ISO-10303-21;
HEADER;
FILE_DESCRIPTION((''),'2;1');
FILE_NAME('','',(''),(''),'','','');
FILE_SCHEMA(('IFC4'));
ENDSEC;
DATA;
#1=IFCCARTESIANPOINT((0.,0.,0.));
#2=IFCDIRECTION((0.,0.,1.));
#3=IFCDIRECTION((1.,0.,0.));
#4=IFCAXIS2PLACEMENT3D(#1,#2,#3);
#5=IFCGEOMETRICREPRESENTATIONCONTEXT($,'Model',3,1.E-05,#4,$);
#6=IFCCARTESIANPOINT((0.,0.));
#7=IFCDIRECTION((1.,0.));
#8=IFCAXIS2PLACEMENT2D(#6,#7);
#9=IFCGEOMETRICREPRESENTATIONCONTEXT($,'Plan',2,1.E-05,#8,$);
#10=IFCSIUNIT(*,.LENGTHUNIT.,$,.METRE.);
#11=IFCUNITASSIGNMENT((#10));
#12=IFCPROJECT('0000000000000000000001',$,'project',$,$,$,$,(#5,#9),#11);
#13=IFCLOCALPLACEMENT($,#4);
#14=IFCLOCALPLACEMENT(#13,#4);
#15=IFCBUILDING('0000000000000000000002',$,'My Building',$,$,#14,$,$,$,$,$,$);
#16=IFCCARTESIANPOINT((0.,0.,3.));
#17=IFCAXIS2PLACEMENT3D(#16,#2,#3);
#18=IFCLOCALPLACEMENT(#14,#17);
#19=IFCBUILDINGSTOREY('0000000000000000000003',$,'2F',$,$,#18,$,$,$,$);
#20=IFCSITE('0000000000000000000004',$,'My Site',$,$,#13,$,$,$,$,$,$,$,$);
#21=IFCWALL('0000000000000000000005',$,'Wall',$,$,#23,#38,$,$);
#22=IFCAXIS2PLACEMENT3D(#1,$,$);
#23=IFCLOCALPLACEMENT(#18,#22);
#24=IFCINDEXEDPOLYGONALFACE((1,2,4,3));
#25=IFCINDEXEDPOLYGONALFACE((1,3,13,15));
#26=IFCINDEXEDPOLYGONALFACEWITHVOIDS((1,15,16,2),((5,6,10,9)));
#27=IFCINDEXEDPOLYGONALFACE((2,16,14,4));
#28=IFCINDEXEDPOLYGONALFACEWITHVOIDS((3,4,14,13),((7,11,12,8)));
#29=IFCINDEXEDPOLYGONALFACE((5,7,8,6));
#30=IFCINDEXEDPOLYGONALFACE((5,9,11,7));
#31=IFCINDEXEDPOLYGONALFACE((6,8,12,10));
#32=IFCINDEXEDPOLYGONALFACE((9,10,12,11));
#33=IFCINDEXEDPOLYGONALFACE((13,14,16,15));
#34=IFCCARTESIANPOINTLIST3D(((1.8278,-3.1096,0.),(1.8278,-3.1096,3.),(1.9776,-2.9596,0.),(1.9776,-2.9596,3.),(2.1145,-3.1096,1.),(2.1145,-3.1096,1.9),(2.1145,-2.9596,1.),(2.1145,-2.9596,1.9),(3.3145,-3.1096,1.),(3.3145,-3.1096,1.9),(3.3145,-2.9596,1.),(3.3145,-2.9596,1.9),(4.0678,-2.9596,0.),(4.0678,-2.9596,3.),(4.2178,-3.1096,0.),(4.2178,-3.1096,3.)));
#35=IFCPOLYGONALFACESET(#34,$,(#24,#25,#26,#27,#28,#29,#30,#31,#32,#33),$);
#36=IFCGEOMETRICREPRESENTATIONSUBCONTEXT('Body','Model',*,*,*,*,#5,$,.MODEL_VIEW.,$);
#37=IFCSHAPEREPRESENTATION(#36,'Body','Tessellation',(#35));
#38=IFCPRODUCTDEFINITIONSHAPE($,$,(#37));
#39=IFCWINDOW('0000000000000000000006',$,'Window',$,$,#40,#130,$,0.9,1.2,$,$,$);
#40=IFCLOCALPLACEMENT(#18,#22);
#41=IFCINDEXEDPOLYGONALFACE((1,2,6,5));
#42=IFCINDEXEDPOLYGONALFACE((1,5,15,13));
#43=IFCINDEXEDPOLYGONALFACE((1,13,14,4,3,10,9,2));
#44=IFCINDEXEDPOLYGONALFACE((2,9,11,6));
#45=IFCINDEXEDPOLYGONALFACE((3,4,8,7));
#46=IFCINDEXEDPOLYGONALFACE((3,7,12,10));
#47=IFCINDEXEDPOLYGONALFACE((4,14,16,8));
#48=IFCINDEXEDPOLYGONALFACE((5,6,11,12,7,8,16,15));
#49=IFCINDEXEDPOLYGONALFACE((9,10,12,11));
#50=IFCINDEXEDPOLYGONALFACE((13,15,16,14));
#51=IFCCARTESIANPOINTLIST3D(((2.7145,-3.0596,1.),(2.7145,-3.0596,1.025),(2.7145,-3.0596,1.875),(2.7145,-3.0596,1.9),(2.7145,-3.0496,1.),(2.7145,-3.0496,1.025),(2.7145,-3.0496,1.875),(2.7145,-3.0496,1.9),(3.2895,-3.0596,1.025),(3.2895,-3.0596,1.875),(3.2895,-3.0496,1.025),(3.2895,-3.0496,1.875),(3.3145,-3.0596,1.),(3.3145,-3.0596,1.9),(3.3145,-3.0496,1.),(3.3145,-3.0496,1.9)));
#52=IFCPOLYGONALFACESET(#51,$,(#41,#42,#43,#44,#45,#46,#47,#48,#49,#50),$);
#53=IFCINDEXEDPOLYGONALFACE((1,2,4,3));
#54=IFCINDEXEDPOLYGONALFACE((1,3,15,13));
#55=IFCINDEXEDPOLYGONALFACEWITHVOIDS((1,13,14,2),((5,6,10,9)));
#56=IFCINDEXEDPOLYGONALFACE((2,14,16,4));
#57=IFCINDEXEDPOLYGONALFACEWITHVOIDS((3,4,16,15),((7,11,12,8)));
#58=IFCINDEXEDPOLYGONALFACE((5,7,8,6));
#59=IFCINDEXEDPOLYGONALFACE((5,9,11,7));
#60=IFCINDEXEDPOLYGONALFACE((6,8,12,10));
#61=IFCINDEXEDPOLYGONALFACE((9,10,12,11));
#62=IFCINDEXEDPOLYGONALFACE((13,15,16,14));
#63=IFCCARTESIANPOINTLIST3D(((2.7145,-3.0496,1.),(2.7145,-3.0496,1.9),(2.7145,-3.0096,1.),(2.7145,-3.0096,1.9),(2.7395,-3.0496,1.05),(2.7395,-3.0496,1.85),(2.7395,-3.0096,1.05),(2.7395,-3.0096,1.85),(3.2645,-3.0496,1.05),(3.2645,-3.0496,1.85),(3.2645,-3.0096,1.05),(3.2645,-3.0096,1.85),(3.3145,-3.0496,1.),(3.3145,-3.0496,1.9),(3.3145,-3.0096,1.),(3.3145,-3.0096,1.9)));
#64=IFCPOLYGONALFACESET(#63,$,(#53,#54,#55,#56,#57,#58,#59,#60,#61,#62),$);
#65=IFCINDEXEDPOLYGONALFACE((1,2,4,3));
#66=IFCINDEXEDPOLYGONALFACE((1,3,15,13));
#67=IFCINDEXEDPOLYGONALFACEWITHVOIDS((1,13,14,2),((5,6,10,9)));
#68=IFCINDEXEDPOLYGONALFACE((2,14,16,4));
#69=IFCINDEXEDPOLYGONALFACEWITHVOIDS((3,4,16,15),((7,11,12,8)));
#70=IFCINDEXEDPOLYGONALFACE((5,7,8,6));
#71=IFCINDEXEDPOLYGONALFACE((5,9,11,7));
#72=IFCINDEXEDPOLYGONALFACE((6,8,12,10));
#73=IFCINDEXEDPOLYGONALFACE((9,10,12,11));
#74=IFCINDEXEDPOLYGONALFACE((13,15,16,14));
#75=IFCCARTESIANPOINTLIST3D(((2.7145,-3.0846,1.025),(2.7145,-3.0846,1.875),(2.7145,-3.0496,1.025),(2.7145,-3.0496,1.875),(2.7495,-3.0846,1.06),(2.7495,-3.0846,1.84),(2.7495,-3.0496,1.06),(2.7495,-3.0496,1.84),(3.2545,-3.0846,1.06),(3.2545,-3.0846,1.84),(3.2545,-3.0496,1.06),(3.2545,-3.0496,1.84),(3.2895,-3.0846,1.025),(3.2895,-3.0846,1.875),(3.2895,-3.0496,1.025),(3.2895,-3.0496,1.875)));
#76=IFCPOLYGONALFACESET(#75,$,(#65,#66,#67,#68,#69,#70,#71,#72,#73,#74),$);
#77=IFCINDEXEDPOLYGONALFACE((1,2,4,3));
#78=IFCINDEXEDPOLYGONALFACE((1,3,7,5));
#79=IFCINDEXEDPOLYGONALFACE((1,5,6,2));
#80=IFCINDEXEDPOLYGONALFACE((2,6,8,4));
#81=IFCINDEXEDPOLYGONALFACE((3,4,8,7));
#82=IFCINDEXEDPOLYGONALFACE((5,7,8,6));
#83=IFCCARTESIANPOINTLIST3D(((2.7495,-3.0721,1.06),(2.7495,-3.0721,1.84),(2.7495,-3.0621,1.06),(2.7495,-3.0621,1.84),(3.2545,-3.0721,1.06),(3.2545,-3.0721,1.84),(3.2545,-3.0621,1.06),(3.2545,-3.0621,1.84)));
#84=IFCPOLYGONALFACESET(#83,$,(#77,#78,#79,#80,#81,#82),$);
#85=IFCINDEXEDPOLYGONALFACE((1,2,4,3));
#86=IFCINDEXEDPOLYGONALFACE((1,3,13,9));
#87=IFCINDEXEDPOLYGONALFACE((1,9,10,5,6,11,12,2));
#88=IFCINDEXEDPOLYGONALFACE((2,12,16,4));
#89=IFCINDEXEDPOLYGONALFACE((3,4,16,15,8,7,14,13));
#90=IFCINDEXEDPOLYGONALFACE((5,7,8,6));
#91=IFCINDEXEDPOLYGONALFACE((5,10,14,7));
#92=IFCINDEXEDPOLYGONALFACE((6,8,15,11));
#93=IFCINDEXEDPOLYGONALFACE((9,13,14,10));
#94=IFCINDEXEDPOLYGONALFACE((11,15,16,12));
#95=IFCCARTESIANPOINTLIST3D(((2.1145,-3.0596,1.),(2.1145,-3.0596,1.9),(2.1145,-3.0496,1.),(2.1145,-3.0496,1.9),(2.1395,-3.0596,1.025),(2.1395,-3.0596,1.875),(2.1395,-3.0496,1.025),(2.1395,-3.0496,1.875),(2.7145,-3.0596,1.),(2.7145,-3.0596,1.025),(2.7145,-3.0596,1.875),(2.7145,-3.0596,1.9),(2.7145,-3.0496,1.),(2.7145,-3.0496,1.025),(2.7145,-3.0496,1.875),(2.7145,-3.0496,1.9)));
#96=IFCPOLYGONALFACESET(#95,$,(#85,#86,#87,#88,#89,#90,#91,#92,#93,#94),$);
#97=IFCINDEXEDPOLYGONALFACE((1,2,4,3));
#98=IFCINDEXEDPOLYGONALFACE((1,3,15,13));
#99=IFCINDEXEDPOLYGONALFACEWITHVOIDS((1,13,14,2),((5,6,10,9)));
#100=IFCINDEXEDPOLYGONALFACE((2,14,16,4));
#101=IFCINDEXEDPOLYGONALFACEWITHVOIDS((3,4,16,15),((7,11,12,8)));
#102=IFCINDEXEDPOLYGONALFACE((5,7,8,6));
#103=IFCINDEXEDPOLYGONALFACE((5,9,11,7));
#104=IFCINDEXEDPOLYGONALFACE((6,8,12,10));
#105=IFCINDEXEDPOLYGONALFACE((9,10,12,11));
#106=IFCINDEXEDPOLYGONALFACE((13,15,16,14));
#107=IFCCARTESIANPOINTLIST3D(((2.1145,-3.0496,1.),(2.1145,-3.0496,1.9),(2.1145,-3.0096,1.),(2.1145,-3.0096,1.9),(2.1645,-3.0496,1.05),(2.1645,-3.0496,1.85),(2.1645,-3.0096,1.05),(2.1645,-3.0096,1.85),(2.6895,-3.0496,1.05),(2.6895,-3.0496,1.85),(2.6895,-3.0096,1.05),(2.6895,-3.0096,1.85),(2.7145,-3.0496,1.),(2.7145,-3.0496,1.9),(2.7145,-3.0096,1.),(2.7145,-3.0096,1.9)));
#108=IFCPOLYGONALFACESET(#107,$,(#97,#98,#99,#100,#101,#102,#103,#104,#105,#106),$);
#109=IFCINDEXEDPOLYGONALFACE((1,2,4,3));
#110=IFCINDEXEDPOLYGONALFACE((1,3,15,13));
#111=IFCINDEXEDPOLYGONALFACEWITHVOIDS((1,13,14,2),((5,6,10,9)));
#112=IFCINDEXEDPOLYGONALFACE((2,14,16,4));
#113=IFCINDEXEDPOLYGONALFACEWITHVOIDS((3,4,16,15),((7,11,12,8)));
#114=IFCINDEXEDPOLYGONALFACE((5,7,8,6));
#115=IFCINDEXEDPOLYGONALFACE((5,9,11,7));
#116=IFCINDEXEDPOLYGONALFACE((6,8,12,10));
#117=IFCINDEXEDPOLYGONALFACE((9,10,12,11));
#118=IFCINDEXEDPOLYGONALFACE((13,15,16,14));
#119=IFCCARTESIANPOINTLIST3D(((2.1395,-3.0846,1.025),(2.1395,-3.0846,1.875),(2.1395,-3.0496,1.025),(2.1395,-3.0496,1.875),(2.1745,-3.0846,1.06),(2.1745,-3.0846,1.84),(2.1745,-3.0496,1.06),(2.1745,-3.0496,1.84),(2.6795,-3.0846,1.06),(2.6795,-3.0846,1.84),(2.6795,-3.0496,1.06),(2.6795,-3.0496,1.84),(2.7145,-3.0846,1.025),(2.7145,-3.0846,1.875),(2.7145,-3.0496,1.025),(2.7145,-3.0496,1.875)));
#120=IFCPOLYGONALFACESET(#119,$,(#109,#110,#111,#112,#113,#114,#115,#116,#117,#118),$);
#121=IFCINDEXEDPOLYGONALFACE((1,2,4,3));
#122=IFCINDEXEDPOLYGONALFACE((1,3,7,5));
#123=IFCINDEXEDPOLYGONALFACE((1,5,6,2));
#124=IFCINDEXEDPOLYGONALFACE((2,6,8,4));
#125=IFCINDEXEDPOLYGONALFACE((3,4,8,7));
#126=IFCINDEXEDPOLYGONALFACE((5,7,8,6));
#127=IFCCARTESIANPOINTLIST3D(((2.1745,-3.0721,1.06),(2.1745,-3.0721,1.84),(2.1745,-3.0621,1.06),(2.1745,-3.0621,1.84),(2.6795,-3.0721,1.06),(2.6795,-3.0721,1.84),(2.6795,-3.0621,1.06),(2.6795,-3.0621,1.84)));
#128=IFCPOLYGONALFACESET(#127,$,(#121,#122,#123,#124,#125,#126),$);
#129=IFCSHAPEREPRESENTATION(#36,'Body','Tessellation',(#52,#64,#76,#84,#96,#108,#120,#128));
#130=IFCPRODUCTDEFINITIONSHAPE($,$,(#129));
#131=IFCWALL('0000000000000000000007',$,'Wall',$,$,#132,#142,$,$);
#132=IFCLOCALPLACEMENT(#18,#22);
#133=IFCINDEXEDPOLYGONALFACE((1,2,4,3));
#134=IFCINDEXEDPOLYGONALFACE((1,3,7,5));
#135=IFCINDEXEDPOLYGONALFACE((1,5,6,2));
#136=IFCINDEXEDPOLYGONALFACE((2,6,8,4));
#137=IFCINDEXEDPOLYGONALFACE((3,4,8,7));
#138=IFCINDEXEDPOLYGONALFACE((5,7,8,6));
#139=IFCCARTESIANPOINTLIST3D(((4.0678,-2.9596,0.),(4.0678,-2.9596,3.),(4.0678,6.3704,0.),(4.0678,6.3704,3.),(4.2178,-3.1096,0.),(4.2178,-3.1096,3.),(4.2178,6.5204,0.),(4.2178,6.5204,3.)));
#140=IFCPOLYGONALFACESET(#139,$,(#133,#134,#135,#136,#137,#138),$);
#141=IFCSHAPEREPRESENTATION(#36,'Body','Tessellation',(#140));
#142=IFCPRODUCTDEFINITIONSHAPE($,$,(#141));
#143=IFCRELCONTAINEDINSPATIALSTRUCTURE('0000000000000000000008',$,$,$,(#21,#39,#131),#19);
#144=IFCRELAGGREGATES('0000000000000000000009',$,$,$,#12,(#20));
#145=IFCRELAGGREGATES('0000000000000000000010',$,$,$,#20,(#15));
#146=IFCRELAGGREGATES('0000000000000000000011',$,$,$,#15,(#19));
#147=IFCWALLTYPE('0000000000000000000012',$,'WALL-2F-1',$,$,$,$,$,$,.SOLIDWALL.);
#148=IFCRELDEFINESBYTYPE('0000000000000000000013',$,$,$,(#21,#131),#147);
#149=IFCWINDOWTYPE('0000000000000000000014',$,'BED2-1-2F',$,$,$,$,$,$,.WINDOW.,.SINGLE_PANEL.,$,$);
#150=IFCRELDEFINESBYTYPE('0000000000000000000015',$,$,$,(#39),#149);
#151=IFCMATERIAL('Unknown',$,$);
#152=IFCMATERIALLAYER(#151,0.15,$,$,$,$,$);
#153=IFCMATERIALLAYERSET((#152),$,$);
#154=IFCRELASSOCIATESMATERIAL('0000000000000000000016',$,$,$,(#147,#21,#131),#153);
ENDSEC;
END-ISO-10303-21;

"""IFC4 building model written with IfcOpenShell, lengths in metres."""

from ifc_helpers import new_model, entity, si_unit, frame, origin_with_axes, origin_2d_with_axis, place, context, subcontext, project, spatial, line, indexed_curve, outline, extrude, shape, source, transform, mapped, material, layer, layer_set, layer_usage, type_object, type_shapes, element, fill, save


model = new_model("IFC4")

# Units and contexts
model_context = context("Model", 3, precision=1e-05, world=origin_with_axes())
plan_context = context("Plan", 2, precision=1e-05, world=origin_2d_with_axis())
body_context_1 = subcontext(model_context, "Body", "Model", "MODEL_VIEW")
body_context_2 = subcontext(plan_context, "Body", "Plan", "PLAN_VIEW")
ifc_project = project(units=[si_unit("LENGTHUNIT", "METRE")], contexts=[model_context, plan_context])

# Site, building, storey
site_placement = place(None, origin_with_axes())
site = spatial("IfcSite", under=ifc_project, at=site_placement, Name="My Site")
building_placement = place(site_placement, origin_with_axes())
building = spatial("IfcBuilding", under=site, at=building_placement, Name="My Building")
storey_placement = place(building_placement, frame((0.0, 0.0, 3.0), z_axis=(0.0, 0.0, 1.0), x_axis=(1.0, 0.0, 0.0)))
storey = spatial("IfcBuildingStorey", under=building, at=storey_placement, Name="2F")

# Shared definitions
ifc_material = material(Name="Unknown")

# Shared definitions
ifc_layer_1 = layer(ifc_material, 0.15)
ifc_layer_set_1 = layer_set([ifc_layer_1])
wall_type_1 = type_object("IfcWallType", Name="WALL-2F-1", PredefinedType="SOLIDWALL", material=ifc_layer_set_1)

# Wall, opening, window
ifc_layer_usage_1 = layer_usage(ifc_layer_set_1, "AXIS2", "POSITIVE", 0.0)
wall_1_placement = place(storey_placement, frame((1.8278, -3.1096, 0.0), z_axis=(0.0, 0.0, 1.0), x_axis=(1.0, 0.0, 0.0)))
wall_1 = element("IfcWall", 1, at=wall_1_placement, inside=storey, type_object=wall_type_1, material=ifc_layer_usage_1, Name="Wall", context=body_context_1, shape_type="SweptSolid", body=[
    extrude(outline(indexed_curve([(0.0, 0.0), (0.1498, 0.15), (2.24, 0.15), (2.39, 0.0)], segments=[line(1, 2, 3, 4, 1)])), origin_with_axes(), (0.0, 0.0, 1.0), 3.0),
])
shared_shape_1 = source(origin_with_axes(), body_context_1, "Body", "SweptSolid", [
    extrude(outline(indexed_curve([(0.0, 0.0), (1.2, 0.0), (1.2, 0.9), (0.0, 0.9)], segments=[line(1, 2, 3, 4, 1)])), frame((0.0, -0.6, 0.0), z_axis=(0.0, -1.0, 0.0), x_axis=(1.0, 0.0, 0.0)), (0.0, 0.0, -1.0), 1.2),
])
opening_1_placement = place(wall_1_placement, frame((1.4867, 0.15, 1.0), z_axis=(0.0, 0.0, 1.0), x_axis=(-1.0, 0.0, 0.0)))
opening_1 = element("IfcOpeningElement", 2, at=opening_1_placement, cuts=wall_1, PredefinedType="OPENING", context=body_context_1, shape_type="MappedRepresentation", body=[
    mapped(shared_shape_1, transform((0.0, 0.0, 0.0), x_axis=(1.0, 0.0, 0.0), y_axis=(0.0, 1.0, 0.0), z_axis=(0.0, 0.0, 1.0), scale=1.0)),
])
window_type = type_object("IfcWindowType", Name="BED2-1-2F", PartitioningType="SINGLE_PANEL", PredefinedType="WINDOW")
shared_shape_2 = source(origin_with_axes(), body_context_1, "Body", "SweptSolid", [
    extrude(outline(indexed_curve([(0.6, 0.0), (0.0, 0.0), (0.0, 0.9), (0.6, 0.9), (0.6, 0.875), (0.025, 0.875), (0.025, 0.025), (0.6, 0.025)], segments=[line(1, 2, 3, 4, 5, 6, 7, 8, 1)])), frame((0.0, 0.09, 0.0), z_axis=(0.0, -1.0, 0.0), x_axis=(1.0, 0.0, 0.0)), (0.0, 0.0, -1.0), 0.01),
    extrude(outline(indexed_curve([(0.0, 0.0), (0.6, 0.0), (0.6, 0.9), (0.0, 0.9)], segments=[line(1, 2, 3, 4, 1)]), holes=[indexed_curve([(0.05, 0.05), (0.575, 0.05), (0.575, 0.85), (0.05, 0.85)], segments=[line(1, 2, 3, 4, 1)])]), frame((0.0, 0.05, 0.0), z_axis=(0.0, -1.0, 0.0), x_axis=(1.0, 0.0, 0.0)), (0.0, 0.0, -1.0), 0.04),
    extrude(outline(indexed_curve([(0.0, 0.0), (0.575, 0.0), (0.575, 0.85), (0.0, 0.85)], segments=[line(1, 2, 3, 4, 1)]), holes=[indexed_curve([(0.035, 0.035), (0.54, 0.035), (0.54, 0.815), (0.035, 0.815)], segments=[line(1, 2, 3, 4, 1)])]), frame((0.025, 0.09, 0.025), z_axis=(0.0, -1.0, 0.0), x_axis=(1.0, 0.0, 0.0)), (0.0, 0.0, -1.0), 0.035),
    extrude(outline(indexed_curve([(0.035, 0.035), (0.54, 0.035), (0.54, 0.815), (0.035, 0.815)], segments=[line(1, 2, 3, 4, 1)])), frame((0.025, 0.1025, 0.025), z_axis=(0.0, -1.0, 0.0), x_axis=(1.0, 0.0, 0.0)), (0.0, 0.0, -1.0), 0.01),
    extrude(outline(indexed_curve([(0.0, 0.9), (0.6, 0.9), (0.6, 0.0), (0.0, 0.0), (0.0, 0.025), (0.575, 0.025), (0.575, 0.875), (0.0, 0.875)], segments=[line(1, 2, 3, 4, 5, 6, 7, 8, 1)])), frame((0.6, 0.09, 0.0), z_axis=(0.0, -1.0, 0.0), x_axis=(1.0, 0.0, 0.0)), (0.0, 0.0, -1.0), 0.01),
    extrude(outline(indexed_curve([(0.0, 0.0), (0.6, 0.0), (0.6, 0.9), (0.0, 0.9)], segments=[line(1, 2, 3, 4, 1)]), holes=[indexed_curve([(0.025, 0.05), (0.55, 0.05), (0.55, 0.85), (0.025, 0.85)], segments=[line(1, 2, 3, 4, 1)])]), frame((0.6, 0.05, 0.0), z_axis=(0.0, -1.0, 0.0), x_axis=(1.0, 0.0, 0.0)), (0.0, 0.0, -1.0), 0.04),
    extrude(outline(indexed_curve([(0.0, 0.0), (0.575, 0.0), (0.575, 0.85), (0.0, 0.85)], segments=[line(1, 2, 3, 4, 1)]), holes=[indexed_curve([(0.035, 0.035), (0.54, 0.035), (0.54, 0.815), (0.035, 0.815)], segments=[line(1, 2, 3, 4, 1)])]), frame((0.6, 0.09, 0.025), z_axis=(0.0, -1.0, 0.0), x_axis=(1.0, 0.0, 0.0)), (0.0, 0.0, -1.0), 0.035),
    extrude(outline(indexed_curve([(0.035, 0.035), (0.54, 0.035), (0.54, 0.815), (0.035, 0.815)], segments=[line(1, 2, 3, 4, 1)])), frame((0.6, 0.1025, 0.025), z_axis=(0.0, -1.0, 0.0), x_axis=(1.0, 0.0, 0.0)), (0.0, 0.0, -1.0), 0.01),
])
shared_shape_3 = source(origin_with_axes(), body_context_2, "Body", "Curve2D", [
    entity("IfcIndexedPolyCurve", entity("IfcCartesianPointList2D", [[0.05, 0.05], [0.575, 0.05]])),
    entity("IfcIndexedPolyCurve", entity("IfcCartesianPointList2D", [[0.0, 0.1], [0.025, 0.1], [0.025, 0.09], [0.05, 0.09], [0.05, 0.05], [0.0, 0.05]]), [entity("IfcLineIndex", [1, 2, 3, 4, 5, 6, 1])]),
    entity("IfcIndexedPolyCurve", entity("IfcCartesianPointList2D", [[0.6, 0.1], [0.6, 0.1], [0.6, 0.09], [0.575, 0.09], [0.575, 0.05], [0.6, 0.05]])),
    entity("IfcIndexedPolyCurve", entity("IfcCartesianPointList2D", [[0.025, 0.09], [0.06, 0.09], [0.06, 0.125], [0.025, 0.125]]), [entity("IfcLineIndex", [1, 2, 3, 4, 1])]),
    entity("IfcIndexedPolyCurve", entity("IfcCartesianPointList2D", [[0.6, 0.09], [0.565, 0.09], [0.565, 0.125], [0.6, 0.125]]), [entity("IfcLineIndex", [1, 2, 3, 4, 1])]),
    entity("IfcIndexedPolyCurve", entity("IfcCartesianPointList2D", [[0.06, 0.09], [0.565, 0.09]])),
    entity("IfcIndexedPolyCurve", entity("IfcCartesianPointList2D", [[0.06, 0.125], [0.565, 0.125]])),
    entity("IfcIndexedPolyCurve", entity("IfcCartesianPointList2D", [[0.06, 0.1075], [0.565, 0.1075]])),
    entity("IfcIndexedPolyCurve", entity("IfcCartesianPointList2D", [[0.625, 0.05], [1.15, 0.05]])),
    entity("IfcIndexedPolyCurve", entity("IfcCartesianPointList2D", [[0.6, 0.1], [0.6, 0.1], [0.6, 0.09], [0.625, 0.09], [0.625, 0.05], [0.6, 0.05]])),
    entity("IfcIndexedPolyCurve", entity("IfcCartesianPointList2D", [[1.2, 0.1], [1.175, 0.1], [1.175, 0.09], [1.15, 0.09], [1.15, 0.05], [1.2, 0.05]]), [entity("IfcLineIndex", [1, 2, 3, 4, 5, 6, 1])]),
    entity("IfcIndexedPolyCurve", entity("IfcCartesianPointList2D", [[0.6, 0.09], [0.635, 0.09], [0.635, 0.125], [0.6, 0.125]]), [entity("IfcLineIndex", [1, 2, 3, 4, 1])]),
    entity("IfcIndexedPolyCurve", entity("IfcCartesianPointList2D", [[1.175, 0.09], [1.14, 0.09], [1.14, 0.125], [1.175, 0.125]]), [entity("IfcLineIndex", [1, 2, 3, 4, 1])]),
    entity("IfcIndexedPolyCurve", entity("IfcCartesianPointList2D", [[0.635, 0.09], [1.14, 0.09]])),
    entity("IfcIndexedPolyCurve", entity("IfcCartesianPointList2D", [[0.635, 0.125], [1.14, 0.125]])),
    entity("IfcIndexedPolyCurve", entity("IfcCartesianPointList2D", [[0.635, 0.1075], [1.14, 0.1075]])),
])
type_shapes(window_type, [shared_shape_2, shared_shape_3])
window_placement = place(opening_1_placement, frame((0.0, 0.0, 0.0), z_axis=(0.0, 0.0, 1.0), x_axis=(1.0, 0.0, 0.0)))
window = element("IfcWindow", 3, at=window_placement, inside=storey, type_object=window_type, Name="Window", OverallHeight=0.9, OverallWidth=1.2, shapes=[
    shape(body_context_1, "Body", "MappedRepresentation", [mapped(shared_shape_2, transform((0.0, 0.0, 0.0), x_axis=(1.0, 0.0, 0.0), y_axis=(0.0, 1.0, 0.0), z_axis=(0.0, 0.0, 1.0), scale=1.0))]),
    shape(body_context_2, "Body", "MappedRepresentation", [mapped(shared_shape_3, transform((0.0, 0.0, 0.0), x_axis=(1.0, 0.0, 0.0), y_axis=(0.0, 1.0, 0.0), z_axis=(0.0, 0.0, 1.0), scale=1.0))]),
])
fill(opening_1, window)

# Wall
ifc_layer_usage_2 = layer_usage(ifc_layer_set_1, "AXIS2", "POSITIVE", 0.0)
wall_2_placement = place(storey_placement, frame((4.2178, -3.1096, 0.0), z_axis=(0.0, 0.0, 1.0), x_axis=(0.0, 1.0, 0.0)))
element("IfcWall", 4, at=wall_2_placement, inside=storey, type_object=wall_type_1, material=ifc_layer_usage_2, Name="Wall", context=body_context_1, shape_type="SweptSolid", body=[
    extrude(outline(indexed_curve([(0.0, 0.0), (0.15, 0.15), (9.48, 0.15), (9.63, 0.0)], segments=[line(1, 2, 3, 4, 1)])), origin_with_axes(), (0.0, 0.0, 1.0), 3.0),
])

save(model, "model.ifc")
